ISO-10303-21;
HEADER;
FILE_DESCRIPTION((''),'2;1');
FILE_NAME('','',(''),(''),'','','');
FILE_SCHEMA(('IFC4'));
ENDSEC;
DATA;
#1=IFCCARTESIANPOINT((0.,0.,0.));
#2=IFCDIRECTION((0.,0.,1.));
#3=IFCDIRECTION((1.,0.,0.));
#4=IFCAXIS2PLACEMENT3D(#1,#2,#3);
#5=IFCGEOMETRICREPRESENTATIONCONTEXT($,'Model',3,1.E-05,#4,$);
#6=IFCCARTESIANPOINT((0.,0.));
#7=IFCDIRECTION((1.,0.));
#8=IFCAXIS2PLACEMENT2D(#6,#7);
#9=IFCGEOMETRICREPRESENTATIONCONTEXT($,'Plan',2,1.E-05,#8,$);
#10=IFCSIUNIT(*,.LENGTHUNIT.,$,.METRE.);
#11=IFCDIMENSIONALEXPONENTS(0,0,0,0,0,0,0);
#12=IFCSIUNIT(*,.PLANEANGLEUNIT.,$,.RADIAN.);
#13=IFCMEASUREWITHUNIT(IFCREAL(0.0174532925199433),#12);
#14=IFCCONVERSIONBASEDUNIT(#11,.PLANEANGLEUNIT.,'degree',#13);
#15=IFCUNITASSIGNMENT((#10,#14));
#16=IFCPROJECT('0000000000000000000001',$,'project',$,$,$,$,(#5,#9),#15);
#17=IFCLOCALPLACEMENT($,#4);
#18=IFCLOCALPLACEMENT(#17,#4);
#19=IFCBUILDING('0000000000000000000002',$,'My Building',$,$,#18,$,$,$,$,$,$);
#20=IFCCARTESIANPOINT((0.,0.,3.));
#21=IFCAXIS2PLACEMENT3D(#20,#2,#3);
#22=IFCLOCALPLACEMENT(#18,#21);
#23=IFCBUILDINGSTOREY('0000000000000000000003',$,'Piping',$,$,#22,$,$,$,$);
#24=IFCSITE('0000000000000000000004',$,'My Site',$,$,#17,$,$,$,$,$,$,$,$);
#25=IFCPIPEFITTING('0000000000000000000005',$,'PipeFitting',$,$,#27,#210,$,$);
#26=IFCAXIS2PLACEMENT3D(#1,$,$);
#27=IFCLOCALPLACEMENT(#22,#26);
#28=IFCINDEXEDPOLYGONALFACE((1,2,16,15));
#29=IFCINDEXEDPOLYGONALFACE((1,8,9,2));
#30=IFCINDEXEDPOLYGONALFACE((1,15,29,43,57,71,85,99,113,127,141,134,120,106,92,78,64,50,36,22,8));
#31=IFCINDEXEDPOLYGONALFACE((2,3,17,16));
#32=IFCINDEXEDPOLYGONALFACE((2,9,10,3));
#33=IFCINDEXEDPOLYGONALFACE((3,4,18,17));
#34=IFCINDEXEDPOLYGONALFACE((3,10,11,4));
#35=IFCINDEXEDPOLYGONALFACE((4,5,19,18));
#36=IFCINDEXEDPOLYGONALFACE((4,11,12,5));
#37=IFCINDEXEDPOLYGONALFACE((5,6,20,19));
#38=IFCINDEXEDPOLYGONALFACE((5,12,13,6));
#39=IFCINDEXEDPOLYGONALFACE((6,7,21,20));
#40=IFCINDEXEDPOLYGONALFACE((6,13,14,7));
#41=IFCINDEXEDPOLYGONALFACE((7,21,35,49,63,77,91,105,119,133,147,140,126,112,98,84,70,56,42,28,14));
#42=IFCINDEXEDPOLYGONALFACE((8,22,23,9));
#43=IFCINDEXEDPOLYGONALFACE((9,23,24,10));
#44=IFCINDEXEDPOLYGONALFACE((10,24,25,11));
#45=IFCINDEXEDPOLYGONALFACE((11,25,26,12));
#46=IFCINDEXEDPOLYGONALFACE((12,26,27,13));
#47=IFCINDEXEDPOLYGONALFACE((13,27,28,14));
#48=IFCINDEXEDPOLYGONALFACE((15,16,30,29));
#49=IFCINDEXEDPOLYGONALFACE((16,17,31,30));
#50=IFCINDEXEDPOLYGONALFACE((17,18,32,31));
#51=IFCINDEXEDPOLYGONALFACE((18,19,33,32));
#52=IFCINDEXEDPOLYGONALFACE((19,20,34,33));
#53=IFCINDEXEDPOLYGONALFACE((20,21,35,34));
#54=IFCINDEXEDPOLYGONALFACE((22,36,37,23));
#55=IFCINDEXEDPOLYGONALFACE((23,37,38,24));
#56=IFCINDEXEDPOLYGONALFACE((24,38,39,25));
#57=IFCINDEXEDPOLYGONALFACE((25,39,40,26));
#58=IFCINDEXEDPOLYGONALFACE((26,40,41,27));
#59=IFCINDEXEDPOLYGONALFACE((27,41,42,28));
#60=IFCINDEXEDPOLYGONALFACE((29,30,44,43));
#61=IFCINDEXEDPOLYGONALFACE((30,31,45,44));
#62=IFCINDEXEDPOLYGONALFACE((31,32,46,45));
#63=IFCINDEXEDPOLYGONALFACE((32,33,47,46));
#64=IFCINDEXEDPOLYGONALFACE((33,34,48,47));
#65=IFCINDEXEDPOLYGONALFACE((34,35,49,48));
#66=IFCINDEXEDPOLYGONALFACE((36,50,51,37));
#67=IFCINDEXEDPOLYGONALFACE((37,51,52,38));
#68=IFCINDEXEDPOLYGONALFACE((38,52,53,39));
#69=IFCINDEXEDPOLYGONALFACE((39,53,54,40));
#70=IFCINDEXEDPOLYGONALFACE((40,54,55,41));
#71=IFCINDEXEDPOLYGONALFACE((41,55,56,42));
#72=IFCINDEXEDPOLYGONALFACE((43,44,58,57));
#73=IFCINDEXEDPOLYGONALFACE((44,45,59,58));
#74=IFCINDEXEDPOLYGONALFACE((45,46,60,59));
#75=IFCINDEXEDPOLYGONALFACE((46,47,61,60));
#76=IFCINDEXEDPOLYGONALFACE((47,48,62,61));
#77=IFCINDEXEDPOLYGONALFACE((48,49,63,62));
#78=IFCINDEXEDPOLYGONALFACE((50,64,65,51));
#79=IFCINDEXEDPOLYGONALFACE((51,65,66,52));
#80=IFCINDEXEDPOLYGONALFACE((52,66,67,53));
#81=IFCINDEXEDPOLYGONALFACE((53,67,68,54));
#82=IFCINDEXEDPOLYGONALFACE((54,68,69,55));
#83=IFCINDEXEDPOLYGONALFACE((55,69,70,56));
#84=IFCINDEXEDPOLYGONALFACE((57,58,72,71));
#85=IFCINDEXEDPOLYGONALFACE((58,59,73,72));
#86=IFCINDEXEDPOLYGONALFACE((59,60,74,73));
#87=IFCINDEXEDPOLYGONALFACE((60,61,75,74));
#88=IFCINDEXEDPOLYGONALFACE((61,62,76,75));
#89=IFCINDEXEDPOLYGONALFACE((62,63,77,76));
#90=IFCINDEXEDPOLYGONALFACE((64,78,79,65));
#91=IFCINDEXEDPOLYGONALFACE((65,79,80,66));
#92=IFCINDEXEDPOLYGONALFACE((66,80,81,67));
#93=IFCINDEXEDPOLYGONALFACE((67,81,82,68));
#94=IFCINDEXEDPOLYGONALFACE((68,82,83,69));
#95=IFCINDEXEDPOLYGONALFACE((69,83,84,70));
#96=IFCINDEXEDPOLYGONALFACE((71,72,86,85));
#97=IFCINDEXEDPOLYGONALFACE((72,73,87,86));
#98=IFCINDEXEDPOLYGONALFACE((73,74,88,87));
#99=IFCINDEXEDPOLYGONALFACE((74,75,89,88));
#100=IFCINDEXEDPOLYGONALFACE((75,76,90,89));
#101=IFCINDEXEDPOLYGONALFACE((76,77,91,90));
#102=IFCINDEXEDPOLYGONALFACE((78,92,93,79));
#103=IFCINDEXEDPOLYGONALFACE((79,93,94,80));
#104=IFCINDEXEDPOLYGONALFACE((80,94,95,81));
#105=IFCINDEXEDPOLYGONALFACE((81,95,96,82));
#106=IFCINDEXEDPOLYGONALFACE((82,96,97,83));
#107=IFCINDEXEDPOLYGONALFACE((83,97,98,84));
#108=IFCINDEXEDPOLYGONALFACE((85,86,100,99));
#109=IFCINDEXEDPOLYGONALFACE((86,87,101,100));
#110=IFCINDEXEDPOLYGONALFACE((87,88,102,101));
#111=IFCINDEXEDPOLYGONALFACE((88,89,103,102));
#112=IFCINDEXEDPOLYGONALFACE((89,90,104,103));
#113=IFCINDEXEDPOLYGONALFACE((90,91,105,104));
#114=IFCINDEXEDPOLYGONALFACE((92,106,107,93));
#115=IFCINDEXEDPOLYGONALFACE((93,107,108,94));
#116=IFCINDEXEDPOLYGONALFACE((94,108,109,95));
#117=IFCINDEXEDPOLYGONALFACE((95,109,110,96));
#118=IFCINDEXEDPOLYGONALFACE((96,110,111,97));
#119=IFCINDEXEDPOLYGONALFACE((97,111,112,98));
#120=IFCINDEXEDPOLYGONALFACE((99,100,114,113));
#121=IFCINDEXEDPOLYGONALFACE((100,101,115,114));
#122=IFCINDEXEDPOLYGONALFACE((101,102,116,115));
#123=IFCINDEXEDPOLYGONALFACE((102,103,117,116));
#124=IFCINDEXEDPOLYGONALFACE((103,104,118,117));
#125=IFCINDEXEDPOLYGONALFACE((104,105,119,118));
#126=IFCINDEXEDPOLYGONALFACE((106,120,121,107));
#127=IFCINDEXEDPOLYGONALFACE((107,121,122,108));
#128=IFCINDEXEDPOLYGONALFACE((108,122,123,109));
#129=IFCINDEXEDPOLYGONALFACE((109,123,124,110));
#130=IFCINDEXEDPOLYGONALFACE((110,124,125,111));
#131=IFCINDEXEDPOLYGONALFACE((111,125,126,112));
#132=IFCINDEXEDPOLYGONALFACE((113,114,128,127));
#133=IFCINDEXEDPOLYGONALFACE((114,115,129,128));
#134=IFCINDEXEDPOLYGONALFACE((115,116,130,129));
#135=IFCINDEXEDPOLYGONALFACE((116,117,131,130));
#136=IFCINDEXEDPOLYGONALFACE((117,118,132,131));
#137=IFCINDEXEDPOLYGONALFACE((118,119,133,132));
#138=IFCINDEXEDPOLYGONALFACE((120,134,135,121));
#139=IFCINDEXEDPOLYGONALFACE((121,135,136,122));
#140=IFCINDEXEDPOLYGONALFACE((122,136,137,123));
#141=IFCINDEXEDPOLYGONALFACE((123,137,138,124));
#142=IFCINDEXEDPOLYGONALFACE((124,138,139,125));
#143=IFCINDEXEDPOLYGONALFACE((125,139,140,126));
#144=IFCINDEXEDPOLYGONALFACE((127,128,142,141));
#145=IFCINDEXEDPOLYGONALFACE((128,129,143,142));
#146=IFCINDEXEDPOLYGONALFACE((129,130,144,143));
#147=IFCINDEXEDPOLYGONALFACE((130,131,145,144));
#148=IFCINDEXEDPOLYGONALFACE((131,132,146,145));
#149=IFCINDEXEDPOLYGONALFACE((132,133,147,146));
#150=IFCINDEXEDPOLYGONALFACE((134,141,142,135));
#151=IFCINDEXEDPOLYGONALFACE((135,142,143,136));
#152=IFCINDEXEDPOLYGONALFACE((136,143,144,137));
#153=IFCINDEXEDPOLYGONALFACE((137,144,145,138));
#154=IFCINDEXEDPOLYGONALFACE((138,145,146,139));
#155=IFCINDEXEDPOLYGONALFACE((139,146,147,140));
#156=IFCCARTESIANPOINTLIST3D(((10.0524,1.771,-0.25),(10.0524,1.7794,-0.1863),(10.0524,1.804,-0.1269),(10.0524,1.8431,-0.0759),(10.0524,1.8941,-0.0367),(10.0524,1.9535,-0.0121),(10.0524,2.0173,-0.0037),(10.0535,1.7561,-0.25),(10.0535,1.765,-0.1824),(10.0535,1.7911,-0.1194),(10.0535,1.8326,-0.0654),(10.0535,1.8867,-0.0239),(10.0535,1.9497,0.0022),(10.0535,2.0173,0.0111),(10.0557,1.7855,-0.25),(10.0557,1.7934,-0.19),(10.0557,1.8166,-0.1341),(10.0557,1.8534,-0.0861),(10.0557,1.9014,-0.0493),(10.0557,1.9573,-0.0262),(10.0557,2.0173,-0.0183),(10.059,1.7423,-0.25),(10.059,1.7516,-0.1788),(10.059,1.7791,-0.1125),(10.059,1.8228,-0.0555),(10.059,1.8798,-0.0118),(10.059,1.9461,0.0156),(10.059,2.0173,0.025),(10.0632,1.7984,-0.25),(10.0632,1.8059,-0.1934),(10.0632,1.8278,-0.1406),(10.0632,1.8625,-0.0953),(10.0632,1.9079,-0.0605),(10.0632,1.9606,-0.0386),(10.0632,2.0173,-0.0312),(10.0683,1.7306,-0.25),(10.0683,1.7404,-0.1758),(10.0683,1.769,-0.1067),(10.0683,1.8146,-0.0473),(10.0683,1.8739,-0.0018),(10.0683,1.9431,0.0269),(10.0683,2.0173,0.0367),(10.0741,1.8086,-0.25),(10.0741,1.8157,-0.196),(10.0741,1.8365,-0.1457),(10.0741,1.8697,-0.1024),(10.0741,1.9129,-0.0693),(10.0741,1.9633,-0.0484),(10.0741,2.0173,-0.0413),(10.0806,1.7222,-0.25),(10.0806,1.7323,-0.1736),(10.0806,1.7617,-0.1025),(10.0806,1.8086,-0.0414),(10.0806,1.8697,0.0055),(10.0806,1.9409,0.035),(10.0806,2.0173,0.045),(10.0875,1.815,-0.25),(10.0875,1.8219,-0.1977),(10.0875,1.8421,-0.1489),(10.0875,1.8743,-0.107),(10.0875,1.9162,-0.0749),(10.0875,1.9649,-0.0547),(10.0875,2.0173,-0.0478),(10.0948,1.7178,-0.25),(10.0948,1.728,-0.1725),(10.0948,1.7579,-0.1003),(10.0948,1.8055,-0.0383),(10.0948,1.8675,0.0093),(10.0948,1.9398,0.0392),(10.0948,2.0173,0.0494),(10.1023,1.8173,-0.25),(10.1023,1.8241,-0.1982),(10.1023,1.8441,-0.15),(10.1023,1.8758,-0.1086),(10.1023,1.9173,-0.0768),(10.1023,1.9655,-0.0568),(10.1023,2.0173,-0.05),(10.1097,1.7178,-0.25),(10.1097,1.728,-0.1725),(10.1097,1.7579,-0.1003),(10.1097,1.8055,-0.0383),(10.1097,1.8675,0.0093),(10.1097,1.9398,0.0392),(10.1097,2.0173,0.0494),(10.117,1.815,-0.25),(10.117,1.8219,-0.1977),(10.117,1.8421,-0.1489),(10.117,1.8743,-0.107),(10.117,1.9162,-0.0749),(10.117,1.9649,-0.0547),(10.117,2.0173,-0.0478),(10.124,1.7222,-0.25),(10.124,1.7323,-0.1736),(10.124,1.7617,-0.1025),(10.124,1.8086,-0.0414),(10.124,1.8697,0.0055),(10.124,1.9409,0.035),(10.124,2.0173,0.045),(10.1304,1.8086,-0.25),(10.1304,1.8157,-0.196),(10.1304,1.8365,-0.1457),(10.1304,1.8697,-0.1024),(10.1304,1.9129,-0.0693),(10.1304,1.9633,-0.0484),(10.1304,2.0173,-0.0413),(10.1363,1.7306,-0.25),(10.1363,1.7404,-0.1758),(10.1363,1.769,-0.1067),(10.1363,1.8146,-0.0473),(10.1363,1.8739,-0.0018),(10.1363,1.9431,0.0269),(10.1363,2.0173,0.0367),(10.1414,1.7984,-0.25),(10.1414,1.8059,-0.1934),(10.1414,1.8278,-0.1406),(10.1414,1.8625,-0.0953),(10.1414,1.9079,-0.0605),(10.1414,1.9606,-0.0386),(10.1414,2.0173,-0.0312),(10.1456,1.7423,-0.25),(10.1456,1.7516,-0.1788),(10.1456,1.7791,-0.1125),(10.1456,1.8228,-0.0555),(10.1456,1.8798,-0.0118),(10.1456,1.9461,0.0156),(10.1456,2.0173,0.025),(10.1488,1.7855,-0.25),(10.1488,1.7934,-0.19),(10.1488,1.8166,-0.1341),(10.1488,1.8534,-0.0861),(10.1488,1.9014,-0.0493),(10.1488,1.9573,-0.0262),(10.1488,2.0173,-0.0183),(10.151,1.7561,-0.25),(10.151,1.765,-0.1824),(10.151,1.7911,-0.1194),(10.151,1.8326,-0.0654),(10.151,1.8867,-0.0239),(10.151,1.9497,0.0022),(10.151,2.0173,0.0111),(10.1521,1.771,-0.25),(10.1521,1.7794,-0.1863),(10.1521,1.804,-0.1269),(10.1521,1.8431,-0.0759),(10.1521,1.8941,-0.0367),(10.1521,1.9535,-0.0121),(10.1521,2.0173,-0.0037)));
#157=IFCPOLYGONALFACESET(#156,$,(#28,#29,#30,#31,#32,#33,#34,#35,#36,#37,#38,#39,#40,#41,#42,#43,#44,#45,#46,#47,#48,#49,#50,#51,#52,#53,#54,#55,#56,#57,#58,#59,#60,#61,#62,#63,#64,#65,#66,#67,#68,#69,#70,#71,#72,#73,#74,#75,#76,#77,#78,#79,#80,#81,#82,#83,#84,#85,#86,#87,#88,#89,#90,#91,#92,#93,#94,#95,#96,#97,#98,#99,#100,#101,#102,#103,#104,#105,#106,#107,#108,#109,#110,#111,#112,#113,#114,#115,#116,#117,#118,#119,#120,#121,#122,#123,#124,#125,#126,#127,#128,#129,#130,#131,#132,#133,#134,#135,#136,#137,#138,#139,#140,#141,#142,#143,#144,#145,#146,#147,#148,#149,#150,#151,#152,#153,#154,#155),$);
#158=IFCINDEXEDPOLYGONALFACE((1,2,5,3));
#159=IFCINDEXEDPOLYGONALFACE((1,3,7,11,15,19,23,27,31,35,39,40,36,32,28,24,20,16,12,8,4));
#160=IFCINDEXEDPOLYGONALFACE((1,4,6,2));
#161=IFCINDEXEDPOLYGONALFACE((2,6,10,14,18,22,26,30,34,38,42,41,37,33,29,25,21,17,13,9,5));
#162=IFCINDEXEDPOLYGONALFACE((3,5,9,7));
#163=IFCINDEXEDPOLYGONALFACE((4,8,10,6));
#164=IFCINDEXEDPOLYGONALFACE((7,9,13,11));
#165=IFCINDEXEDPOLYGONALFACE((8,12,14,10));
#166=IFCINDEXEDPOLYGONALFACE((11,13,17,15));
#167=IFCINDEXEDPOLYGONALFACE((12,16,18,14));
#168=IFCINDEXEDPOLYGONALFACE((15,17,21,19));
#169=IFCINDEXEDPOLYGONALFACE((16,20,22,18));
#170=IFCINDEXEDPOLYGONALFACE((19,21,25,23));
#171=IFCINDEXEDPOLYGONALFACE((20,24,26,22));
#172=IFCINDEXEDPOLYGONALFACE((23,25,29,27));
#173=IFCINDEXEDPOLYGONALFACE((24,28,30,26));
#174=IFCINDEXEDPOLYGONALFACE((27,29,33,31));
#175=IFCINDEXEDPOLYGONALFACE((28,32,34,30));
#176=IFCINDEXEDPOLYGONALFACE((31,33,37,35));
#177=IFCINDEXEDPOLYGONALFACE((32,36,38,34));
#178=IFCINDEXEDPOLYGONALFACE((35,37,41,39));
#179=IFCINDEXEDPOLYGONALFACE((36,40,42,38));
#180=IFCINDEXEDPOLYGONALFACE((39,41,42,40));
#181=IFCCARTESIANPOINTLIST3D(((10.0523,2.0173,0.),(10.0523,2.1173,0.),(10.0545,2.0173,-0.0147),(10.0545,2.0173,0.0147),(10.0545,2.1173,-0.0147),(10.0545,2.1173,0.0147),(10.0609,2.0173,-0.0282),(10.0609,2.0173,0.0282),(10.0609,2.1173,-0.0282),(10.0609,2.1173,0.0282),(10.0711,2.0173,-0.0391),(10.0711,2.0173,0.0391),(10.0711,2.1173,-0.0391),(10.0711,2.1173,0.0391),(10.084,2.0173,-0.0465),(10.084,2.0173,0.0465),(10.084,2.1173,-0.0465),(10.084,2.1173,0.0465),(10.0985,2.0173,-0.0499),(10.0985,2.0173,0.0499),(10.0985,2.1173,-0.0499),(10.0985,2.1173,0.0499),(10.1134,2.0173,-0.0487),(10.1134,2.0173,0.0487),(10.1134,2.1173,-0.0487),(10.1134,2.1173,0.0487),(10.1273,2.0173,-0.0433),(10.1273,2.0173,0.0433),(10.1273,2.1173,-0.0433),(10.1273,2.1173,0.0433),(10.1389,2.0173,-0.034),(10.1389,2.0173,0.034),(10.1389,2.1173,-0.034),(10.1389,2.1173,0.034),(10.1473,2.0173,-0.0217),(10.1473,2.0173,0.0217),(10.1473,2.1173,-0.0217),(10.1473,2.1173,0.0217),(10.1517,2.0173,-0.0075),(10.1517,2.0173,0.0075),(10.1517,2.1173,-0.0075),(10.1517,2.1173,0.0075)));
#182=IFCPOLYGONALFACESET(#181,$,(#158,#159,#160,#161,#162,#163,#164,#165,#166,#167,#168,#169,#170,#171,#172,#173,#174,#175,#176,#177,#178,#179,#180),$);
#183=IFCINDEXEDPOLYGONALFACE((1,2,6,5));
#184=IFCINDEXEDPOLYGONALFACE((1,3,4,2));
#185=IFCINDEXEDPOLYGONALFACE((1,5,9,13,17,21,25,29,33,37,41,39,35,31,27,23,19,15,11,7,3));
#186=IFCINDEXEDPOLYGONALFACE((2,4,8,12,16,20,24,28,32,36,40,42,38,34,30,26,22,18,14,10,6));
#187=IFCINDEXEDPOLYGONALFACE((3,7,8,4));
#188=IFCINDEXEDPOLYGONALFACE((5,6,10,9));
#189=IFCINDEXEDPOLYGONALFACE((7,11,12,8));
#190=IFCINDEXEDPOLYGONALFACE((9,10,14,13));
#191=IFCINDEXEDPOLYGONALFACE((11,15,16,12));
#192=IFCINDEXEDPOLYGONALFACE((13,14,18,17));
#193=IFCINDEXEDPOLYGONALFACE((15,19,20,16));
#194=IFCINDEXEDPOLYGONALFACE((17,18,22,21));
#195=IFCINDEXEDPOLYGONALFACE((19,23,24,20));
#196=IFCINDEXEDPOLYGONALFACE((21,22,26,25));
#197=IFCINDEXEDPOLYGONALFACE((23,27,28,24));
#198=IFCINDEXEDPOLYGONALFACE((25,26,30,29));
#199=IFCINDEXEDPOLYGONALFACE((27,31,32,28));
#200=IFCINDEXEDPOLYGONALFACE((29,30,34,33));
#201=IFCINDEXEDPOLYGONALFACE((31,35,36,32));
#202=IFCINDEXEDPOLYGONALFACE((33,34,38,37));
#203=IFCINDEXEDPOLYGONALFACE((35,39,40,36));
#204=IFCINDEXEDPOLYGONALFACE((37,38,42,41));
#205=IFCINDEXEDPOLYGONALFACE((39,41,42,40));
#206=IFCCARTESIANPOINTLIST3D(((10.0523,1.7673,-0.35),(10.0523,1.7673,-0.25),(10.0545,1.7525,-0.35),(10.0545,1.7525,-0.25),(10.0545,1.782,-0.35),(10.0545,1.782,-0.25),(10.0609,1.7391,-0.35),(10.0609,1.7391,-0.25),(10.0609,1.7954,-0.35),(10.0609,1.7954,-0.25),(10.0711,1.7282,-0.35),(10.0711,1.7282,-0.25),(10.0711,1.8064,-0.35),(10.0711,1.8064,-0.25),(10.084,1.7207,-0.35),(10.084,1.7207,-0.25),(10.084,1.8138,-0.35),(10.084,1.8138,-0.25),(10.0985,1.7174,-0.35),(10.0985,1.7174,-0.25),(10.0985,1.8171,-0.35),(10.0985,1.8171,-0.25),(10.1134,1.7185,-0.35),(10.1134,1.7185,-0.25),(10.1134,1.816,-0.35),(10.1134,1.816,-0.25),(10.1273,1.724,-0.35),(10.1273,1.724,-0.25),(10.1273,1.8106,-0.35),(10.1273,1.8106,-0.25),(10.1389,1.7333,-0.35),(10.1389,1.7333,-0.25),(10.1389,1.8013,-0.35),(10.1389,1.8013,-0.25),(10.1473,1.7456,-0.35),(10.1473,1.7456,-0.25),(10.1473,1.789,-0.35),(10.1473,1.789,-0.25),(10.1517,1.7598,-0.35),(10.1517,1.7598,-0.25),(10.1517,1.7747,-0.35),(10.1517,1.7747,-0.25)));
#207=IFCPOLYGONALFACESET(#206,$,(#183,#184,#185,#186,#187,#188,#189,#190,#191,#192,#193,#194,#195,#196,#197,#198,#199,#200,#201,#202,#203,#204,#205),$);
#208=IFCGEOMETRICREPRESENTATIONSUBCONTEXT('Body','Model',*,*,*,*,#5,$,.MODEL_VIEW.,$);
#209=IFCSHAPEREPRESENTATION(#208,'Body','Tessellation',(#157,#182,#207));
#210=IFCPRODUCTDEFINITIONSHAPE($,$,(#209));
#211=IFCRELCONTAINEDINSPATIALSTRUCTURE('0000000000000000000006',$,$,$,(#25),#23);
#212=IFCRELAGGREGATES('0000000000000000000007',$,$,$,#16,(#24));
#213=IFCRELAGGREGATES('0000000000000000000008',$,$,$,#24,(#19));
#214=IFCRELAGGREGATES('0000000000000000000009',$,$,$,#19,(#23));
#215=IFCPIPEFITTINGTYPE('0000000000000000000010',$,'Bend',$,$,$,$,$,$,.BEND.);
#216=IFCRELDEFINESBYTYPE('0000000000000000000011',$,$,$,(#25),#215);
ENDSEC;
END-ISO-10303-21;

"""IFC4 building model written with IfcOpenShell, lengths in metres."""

from ifc_helpers import new_model, entity, si_unit, converted_unit, frame, origin_with_axes, origin_2d_with_axis, place, context, subcontext, project, spatial, circle, extrude, source, transform, mapped, type_object, type_shapes, element, save


model = new_model("IFC4")

# Units and contexts
model_context = context("Model", 3, precision=1e-05, world=origin_with_axes())
plan_context = context("Plan", 2, precision=1e-05, world=origin_2d_with_axis())
body_context = subcontext(model_context, "Body", "Model", "MODEL_VIEW")
ifc_project = project(units=[si_unit("LENGTHUNIT", "METRE"), converted_unit("PLANEANGLEUNIT", "degree", entity("IfcReal", 0.0174532925199433), si_unit("PLANEANGLEUNIT", "RADIAN"), dimensions=[0, 0, 0, 0, 0, 0, 0])], contexts=[model_context, plan_context])

# Site, building, storey
site_placement = place(None, origin_with_axes())
site = spatial("IfcSite", under=ifc_project, at=site_placement, Name="My Site")
building_placement = place(site_placement, origin_with_axes())
building = spatial("IfcBuilding", under=site, at=building_placement, Name="My Building")
storey_placement = place(building_placement, frame((0.0, 0.0, 3.0), z_axis=(0.0, 0.0, 1.0), x_axis=(1.0, 0.0, 0.0)))
storey = spatial("IfcBuildingStorey", under=building, at=storey_placement, Name="Piping")

# Pipe fitting
pipe_fitting_type = type_object("IfcPipeFittingType", Name="Bend", PredefinedType="BEND")
shared_shape = source(origin_with_axes(), body_context, "Body", "SolidModel", [
    entity("IfcSweptDiskSolid", entity("IfcIndexedPolyCurve", entity("IfcCartesianPointList3D", [[0.0, 0.0, -0.1], [0.0, -0.0732, -0.2768], [0.0, -0.25, -0.35]]), [entity("IfcArcIndex", [1, 2, 3])]), 0.05),
    extrude(circle(Radius=0.05), origin_with_axes(), (0.0, 0.0, -1.0), 0.1),
    extrude(circle(Radius=0.05), frame((0.0, -0.25, -0.35), z_axis=(0.0, -1.0, 0.0), x_axis=(1.0, 0.0, 0.0)), (0.0, 0.0, 1.0), 0.1),
])
type_shapes(pipe_fitting_type, [shared_shape])
for number, where, z_axis, x_axis, name in (
    (1, (10.1023, 2.1173, 0.0), (0.0, 1.0, 0.0), (-1.0, 0.0, 0.0), "PipeFitting"),
):
    element("IfcPipeFitting", number, at=place(storey_placement, frame(where, z_axis=z_axis, x_axis=x_axis)), inside=storey, type_object=pipe_fitting_type, Name=name, context=body_context, shape_type="MappedRepresentation", body=[
        mapped(shared_shape, transform((0.0, 0.0, 0.0), x_axis=(1.0, 0.0, 0.0), y_axis=(0.0, 1.0, 0.0), z_axis=(0.0, 0.0, 1.0), scale=1.0)),
    ])

save(model, "model.ifc")
